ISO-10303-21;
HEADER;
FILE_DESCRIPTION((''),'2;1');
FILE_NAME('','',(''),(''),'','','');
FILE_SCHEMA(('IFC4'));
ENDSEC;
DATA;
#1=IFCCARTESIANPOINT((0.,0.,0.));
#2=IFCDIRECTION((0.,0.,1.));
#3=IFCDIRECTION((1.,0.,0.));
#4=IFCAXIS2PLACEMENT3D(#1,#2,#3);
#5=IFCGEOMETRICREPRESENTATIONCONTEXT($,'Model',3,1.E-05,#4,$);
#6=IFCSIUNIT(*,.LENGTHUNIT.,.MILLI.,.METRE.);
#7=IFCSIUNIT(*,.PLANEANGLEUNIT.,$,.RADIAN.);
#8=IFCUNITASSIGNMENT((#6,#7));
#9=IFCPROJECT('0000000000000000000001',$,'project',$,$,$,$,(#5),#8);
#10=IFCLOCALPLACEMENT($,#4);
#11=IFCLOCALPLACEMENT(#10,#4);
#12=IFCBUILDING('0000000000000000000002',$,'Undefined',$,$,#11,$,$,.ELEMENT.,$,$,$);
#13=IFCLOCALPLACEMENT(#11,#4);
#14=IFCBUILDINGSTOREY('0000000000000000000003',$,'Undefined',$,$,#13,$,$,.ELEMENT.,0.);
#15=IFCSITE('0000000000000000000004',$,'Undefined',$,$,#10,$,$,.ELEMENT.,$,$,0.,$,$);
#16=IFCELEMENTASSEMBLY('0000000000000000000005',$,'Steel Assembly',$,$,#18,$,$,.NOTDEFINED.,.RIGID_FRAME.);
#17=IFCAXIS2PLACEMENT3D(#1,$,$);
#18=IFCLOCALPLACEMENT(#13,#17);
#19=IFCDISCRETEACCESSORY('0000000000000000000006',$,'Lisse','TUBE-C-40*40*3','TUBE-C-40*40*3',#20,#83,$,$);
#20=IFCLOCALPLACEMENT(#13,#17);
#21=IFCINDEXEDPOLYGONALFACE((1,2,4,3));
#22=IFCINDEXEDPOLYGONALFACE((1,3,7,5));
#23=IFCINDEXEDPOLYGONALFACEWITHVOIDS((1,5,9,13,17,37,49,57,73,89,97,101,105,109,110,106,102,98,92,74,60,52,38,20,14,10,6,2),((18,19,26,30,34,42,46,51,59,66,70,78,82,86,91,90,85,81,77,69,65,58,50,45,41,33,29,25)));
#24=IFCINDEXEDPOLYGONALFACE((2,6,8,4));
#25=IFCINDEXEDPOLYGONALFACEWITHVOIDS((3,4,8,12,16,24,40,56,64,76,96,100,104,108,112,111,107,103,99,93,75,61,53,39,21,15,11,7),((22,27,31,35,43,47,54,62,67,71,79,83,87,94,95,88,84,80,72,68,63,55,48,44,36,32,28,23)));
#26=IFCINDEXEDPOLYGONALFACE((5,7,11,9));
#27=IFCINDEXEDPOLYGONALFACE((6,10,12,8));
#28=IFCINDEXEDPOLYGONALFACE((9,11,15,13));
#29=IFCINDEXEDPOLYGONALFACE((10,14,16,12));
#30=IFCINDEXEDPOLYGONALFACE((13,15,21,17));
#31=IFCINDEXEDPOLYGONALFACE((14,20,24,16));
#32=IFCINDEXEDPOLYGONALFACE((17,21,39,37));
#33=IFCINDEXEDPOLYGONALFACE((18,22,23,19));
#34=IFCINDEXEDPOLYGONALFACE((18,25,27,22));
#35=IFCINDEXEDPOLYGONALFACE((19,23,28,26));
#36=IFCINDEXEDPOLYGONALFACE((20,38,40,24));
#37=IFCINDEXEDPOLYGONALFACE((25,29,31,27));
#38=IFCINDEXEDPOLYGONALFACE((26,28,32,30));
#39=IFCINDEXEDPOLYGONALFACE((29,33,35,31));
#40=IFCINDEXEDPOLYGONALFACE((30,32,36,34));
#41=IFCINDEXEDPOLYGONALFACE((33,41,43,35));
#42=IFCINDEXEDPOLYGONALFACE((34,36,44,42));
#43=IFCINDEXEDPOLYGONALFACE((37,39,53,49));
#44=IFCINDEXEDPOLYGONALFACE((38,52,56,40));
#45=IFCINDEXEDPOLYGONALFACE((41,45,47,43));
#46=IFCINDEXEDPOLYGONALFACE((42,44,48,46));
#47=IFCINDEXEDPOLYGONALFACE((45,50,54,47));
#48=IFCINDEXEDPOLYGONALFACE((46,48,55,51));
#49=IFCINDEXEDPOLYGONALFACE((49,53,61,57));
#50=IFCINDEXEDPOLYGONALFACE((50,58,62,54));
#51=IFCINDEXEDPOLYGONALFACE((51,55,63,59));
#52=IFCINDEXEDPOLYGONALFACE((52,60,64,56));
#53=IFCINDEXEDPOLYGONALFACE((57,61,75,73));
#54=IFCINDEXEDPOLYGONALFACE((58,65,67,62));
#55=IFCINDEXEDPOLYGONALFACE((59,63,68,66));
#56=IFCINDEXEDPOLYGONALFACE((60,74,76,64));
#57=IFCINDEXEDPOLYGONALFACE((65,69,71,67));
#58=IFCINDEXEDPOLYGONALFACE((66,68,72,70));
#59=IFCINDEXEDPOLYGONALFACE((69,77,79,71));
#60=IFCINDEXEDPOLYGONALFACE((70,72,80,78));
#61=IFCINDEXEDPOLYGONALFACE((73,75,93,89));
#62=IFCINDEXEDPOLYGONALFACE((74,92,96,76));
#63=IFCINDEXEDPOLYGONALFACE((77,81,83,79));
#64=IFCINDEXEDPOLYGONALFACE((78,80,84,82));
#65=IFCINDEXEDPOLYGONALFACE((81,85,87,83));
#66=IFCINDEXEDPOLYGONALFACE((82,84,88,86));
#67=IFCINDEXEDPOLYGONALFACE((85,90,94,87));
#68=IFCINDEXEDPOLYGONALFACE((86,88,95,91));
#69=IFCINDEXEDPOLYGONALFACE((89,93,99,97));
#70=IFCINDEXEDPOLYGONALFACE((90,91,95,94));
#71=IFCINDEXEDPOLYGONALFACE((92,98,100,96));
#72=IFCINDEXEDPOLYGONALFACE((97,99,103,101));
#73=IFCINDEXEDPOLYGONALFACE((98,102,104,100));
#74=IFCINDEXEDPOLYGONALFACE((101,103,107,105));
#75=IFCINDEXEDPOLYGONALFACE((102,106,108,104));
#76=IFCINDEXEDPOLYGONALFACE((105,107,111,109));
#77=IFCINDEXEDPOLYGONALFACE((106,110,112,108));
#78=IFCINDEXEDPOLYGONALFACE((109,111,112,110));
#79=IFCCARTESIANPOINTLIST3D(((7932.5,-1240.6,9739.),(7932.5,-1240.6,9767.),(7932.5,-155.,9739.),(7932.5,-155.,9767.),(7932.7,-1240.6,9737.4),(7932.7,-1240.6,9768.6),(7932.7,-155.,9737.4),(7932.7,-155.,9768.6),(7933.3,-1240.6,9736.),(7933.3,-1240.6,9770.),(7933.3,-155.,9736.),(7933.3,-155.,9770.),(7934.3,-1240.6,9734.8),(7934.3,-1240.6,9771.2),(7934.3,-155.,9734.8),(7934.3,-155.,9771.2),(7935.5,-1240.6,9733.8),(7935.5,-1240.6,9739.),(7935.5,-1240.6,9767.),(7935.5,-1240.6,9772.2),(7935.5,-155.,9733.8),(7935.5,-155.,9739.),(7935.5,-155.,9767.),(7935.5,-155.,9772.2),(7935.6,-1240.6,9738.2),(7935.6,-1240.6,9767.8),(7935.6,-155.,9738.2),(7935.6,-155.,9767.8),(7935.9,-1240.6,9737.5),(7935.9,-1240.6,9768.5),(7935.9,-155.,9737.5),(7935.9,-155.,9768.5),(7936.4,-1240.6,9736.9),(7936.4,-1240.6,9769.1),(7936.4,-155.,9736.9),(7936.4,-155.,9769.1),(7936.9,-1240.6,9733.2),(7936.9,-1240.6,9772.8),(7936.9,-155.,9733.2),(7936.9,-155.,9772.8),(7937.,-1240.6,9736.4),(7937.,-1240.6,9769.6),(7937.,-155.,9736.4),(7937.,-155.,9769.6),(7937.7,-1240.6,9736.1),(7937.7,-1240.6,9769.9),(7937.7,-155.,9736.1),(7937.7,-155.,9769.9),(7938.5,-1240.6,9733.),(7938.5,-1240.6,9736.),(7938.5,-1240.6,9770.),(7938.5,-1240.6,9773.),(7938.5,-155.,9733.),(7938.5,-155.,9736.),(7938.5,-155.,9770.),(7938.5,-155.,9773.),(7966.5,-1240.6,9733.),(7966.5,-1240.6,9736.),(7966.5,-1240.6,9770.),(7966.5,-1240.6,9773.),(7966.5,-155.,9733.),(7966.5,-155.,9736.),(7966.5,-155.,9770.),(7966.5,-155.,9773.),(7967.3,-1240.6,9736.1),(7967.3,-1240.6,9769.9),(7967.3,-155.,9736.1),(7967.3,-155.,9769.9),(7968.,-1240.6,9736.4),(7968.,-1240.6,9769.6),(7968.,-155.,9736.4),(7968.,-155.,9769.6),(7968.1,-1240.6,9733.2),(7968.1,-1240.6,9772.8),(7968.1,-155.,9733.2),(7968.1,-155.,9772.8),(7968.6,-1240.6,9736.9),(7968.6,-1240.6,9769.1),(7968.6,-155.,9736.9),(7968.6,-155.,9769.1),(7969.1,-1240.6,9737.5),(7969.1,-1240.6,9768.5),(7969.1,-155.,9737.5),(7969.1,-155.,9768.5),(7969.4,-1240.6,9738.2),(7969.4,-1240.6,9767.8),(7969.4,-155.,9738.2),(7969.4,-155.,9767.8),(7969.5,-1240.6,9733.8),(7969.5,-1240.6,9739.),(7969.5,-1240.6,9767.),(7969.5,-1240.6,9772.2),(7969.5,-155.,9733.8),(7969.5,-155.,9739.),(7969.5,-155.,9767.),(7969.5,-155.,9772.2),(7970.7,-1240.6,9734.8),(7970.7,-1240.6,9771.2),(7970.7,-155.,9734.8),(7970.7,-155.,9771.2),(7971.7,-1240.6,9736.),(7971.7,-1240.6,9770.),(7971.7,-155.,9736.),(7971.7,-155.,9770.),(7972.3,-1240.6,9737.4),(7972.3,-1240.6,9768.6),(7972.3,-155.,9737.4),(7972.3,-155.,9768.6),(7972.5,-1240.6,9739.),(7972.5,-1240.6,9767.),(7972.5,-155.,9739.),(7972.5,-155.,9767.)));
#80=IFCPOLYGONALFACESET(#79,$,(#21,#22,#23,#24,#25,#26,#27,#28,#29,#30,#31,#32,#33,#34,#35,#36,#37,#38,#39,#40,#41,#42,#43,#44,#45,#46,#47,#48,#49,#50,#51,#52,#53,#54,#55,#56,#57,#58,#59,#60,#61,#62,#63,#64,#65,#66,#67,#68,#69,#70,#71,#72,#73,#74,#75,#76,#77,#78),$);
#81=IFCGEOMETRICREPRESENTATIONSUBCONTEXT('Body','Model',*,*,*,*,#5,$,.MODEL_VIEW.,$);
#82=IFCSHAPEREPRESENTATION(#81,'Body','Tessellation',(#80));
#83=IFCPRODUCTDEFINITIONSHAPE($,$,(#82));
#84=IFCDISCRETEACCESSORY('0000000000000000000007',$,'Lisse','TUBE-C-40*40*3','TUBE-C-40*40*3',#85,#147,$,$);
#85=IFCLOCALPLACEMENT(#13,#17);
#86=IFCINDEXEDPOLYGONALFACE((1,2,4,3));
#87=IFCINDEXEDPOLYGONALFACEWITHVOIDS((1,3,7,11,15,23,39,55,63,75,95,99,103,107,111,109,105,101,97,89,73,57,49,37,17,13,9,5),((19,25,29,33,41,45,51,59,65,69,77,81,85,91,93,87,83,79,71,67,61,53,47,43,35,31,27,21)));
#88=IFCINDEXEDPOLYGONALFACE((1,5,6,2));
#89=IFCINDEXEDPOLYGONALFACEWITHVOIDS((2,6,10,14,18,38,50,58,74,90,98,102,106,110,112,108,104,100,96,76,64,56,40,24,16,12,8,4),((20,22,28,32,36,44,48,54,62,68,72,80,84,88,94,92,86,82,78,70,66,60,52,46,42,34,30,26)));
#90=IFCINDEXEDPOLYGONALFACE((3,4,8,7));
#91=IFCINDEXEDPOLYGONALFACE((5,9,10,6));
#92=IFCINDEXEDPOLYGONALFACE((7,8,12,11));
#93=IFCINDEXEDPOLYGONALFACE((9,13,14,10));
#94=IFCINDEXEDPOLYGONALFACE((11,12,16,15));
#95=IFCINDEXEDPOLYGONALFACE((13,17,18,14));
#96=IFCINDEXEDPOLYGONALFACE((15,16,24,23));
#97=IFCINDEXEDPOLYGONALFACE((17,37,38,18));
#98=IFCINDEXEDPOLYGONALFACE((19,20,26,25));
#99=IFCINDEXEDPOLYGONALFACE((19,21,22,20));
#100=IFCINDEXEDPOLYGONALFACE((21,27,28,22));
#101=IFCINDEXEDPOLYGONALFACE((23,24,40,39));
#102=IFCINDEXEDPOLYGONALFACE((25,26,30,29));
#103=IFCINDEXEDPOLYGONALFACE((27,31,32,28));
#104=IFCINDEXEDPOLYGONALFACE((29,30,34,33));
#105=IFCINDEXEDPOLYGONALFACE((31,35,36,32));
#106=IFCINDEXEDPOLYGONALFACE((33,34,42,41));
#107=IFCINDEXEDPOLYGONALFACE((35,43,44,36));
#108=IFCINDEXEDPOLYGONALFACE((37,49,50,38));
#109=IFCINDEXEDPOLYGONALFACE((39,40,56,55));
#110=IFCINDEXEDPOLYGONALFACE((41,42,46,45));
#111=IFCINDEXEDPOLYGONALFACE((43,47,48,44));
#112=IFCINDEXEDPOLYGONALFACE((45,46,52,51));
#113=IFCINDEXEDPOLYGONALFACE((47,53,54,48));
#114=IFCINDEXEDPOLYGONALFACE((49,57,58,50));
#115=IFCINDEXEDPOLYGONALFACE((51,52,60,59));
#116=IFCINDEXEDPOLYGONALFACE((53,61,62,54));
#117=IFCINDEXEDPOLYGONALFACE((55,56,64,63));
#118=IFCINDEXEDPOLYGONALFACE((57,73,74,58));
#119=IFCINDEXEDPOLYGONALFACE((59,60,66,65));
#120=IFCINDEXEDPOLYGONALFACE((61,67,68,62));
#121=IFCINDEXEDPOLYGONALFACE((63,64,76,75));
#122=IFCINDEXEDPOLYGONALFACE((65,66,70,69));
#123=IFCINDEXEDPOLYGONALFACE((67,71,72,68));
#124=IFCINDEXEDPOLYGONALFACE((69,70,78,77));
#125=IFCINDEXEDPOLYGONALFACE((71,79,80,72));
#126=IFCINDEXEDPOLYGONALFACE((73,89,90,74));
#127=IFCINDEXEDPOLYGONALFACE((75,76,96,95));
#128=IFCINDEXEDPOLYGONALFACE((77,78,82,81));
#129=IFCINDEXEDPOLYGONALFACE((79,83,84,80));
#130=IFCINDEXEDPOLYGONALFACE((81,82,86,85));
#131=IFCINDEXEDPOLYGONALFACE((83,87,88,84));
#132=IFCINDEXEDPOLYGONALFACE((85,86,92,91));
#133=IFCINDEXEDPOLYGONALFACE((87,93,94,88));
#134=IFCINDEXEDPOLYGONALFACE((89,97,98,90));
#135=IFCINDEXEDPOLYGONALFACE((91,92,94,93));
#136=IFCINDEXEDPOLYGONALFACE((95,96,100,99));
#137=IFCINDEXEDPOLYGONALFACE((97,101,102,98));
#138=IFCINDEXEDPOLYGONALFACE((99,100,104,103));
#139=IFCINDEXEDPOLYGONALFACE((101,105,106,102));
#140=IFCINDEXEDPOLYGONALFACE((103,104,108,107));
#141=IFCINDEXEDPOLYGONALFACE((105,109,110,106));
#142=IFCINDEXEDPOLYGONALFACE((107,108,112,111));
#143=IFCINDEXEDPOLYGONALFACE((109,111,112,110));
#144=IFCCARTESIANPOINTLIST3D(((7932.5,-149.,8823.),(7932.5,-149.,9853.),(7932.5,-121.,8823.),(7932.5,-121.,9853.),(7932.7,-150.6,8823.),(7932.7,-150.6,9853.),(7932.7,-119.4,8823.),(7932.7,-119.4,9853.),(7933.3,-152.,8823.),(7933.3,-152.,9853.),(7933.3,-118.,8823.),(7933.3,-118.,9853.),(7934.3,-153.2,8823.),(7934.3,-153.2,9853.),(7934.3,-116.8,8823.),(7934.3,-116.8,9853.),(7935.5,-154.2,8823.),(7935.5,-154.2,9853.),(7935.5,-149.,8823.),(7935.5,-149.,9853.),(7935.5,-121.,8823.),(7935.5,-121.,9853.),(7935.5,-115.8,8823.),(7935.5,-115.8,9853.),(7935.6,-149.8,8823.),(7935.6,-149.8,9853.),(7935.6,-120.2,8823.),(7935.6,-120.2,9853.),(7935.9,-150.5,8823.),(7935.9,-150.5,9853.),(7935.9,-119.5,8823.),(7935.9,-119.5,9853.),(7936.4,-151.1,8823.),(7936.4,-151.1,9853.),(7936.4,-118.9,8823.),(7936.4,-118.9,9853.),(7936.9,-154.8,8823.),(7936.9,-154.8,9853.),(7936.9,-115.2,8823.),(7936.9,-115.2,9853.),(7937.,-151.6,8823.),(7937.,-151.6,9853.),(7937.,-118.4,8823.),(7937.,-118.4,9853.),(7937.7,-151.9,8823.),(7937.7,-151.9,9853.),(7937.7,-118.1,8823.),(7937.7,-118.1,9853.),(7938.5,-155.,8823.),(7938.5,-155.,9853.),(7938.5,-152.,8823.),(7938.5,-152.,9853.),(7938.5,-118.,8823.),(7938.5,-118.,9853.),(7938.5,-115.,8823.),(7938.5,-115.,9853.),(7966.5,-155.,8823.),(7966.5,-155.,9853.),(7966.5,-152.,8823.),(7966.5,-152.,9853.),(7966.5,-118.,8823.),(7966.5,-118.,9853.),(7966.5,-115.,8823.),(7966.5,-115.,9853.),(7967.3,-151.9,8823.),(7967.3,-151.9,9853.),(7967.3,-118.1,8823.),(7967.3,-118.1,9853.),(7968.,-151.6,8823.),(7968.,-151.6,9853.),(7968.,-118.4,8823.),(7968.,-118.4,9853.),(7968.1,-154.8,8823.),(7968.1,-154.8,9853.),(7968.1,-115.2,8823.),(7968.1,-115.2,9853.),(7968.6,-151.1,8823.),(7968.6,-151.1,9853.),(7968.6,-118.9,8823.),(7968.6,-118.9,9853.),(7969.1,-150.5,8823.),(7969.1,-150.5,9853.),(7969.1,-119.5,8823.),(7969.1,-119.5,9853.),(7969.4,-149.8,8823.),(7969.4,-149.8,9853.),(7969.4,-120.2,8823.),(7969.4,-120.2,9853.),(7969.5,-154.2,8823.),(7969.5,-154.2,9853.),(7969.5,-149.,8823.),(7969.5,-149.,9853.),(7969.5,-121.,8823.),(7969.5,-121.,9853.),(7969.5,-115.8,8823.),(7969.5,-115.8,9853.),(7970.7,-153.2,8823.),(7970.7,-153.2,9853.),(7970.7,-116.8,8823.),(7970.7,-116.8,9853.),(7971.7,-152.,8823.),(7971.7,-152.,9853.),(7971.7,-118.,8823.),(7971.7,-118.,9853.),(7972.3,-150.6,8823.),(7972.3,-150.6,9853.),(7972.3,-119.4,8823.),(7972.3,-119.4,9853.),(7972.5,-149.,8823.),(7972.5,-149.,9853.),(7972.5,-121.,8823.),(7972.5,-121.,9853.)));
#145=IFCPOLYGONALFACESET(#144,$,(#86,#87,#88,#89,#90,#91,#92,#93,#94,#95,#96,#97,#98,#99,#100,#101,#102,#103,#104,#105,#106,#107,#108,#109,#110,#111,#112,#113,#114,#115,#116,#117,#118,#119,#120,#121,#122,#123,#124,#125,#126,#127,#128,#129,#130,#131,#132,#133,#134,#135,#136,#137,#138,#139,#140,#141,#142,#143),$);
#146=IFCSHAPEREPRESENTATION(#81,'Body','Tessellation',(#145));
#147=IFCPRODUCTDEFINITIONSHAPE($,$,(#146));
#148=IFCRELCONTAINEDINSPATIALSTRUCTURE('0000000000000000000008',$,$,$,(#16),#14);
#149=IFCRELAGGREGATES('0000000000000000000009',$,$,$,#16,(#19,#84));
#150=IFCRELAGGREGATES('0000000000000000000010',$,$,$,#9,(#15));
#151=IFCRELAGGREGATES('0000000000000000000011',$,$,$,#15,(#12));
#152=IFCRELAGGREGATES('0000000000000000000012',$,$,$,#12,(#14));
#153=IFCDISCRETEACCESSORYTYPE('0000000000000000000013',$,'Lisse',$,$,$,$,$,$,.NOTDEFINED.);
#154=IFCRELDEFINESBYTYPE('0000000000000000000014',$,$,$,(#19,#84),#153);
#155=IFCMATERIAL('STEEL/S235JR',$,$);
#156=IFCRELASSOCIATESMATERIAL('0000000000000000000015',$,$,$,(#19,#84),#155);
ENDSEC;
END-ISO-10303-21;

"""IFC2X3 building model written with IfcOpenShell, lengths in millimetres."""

from ifc_helpers import new_model, si_unit, frame, origin_with_axes, origin_2d_with_axis, place, context, subcontext, project, spatial, hollow_rectangle, extrude, material, type_object, element, aggregate, save


model = new_model("IFC2X3")

# Units and contexts
model_context = context("Model", 3, precision=1e-05, world=origin_with_axes())
body_context = subcontext(model_context, "Body", "Model", "MODEL_VIEW")
ifc_project = project(units=[si_unit("LENGTHUNIT", "METRE", prefix="MILLI"), si_unit("PLANEANGLEUNIT", "RADIAN")], contexts=[model_context])

# Site, building, storey
site_placement = place(None, origin_with_axes())
site = spatial("IfcSite", under=ifc_project, at=site_placement, Name="Undefined", CompositionType="ELEMENT", RefElevation=0.0)
building_placement = place(site_placement, origin_with_axes())
building = spatial("IfcBuilding", under=site, at=building_placement, Name="Undefined", CompositionType="ELEMENT")
storey_placement = place(building_placement, origin_with_axes())
storey = spatial("IfcBuildingStorey", under=building, at=storey_placement, Name="Undefined", CompositionType="ELEMENT", Elevation=0.0)

# Element assembly
assembly_1_placement = place(storey_placement, origin_with_axes())
assembly_1 = element("IfcElementAssembly", 1, at=assembly_1_placement, inside=storey, Name="Steel Assembly", AssemblyPlace="NOTDEFINED", PredefinedType="RIGID_FRAME")
ifc_material_1 = material(Name="STEEL/S235JR")

# Discrete accessories
discrete_accessory_type_1 = type_object("IfcDiscreteAccessoryType", Name="Lisse")
discrete_accessory_1_placement = place(assembly_1_placement, frame((7952.5, -155.0, 9753.0), z_axis=(-1.0, 0.0, 0.0), x_axis=(0.0, -1.0, 0.0)))
discrete_accessory_1 = element("IfcDiscreteAccessory", 2, at=discrete_accessory_1_placement, type_object=discrete_accessory_type_1, material=ifc_material_1, Name="Lisse", Description="TUBE-C-40*40*3", ObjectType="TUBE-C-40*40*3", context=body_context, shape_type="SweptSolid", body=[
    extrude(hollow_rectangle(XDim=40.0, YDim=40.0, WallThickness=3.0, InnerFilletRadius=3.0, OuterFilletRadius=6.0, at=origin_2d_with_axis()), frame((1085.6, 0.0, 0.0), z_axis=(-1.0, 0.0, 0.0), x_axis=(0.0, -1.0, 0.0)), (0.0, 0.0, 1.0), 1085.6),
])
discrete_accessory_2_placement = place(assembly_1_placement, frame((7952.5, -135.0, 9853.0), z_axis=(0.0, 1.0, 0.0), x_axis=(0.0, 0.0, -1.0)))
discrete_accessory_2 = element("IfcDiscreteAccessory", 3, at=discrete_accessory_2_placement, type_object=discrete_accessory_type_1, material=ifc_material_1, Name="Lisse", Description="TUBE-C-40*40*3", ObjectType="TUBE-C-40*40*3", context=body_context, shape_type="SweptSolid", body=[
    extrude(hollow_rectangle(XDim=40.0, YDim=40.0, WallThickness=3.0, InnerFilletRadius=3.0, OuterFilletRadius=6.0, at=origin_2d_with_axis()), frame((1030.0, 0.0, 0.0), z_axis=(-1.0, 0.0, 0.0), x_axis=(0.0, -1.0, 0.0)), (0.0, 0.0, 1.0), 1030.0),
])
aggregate(assembly_1, [discrete_accessory_1, discrete_accessory_2])

save(model, "model.ifc")
